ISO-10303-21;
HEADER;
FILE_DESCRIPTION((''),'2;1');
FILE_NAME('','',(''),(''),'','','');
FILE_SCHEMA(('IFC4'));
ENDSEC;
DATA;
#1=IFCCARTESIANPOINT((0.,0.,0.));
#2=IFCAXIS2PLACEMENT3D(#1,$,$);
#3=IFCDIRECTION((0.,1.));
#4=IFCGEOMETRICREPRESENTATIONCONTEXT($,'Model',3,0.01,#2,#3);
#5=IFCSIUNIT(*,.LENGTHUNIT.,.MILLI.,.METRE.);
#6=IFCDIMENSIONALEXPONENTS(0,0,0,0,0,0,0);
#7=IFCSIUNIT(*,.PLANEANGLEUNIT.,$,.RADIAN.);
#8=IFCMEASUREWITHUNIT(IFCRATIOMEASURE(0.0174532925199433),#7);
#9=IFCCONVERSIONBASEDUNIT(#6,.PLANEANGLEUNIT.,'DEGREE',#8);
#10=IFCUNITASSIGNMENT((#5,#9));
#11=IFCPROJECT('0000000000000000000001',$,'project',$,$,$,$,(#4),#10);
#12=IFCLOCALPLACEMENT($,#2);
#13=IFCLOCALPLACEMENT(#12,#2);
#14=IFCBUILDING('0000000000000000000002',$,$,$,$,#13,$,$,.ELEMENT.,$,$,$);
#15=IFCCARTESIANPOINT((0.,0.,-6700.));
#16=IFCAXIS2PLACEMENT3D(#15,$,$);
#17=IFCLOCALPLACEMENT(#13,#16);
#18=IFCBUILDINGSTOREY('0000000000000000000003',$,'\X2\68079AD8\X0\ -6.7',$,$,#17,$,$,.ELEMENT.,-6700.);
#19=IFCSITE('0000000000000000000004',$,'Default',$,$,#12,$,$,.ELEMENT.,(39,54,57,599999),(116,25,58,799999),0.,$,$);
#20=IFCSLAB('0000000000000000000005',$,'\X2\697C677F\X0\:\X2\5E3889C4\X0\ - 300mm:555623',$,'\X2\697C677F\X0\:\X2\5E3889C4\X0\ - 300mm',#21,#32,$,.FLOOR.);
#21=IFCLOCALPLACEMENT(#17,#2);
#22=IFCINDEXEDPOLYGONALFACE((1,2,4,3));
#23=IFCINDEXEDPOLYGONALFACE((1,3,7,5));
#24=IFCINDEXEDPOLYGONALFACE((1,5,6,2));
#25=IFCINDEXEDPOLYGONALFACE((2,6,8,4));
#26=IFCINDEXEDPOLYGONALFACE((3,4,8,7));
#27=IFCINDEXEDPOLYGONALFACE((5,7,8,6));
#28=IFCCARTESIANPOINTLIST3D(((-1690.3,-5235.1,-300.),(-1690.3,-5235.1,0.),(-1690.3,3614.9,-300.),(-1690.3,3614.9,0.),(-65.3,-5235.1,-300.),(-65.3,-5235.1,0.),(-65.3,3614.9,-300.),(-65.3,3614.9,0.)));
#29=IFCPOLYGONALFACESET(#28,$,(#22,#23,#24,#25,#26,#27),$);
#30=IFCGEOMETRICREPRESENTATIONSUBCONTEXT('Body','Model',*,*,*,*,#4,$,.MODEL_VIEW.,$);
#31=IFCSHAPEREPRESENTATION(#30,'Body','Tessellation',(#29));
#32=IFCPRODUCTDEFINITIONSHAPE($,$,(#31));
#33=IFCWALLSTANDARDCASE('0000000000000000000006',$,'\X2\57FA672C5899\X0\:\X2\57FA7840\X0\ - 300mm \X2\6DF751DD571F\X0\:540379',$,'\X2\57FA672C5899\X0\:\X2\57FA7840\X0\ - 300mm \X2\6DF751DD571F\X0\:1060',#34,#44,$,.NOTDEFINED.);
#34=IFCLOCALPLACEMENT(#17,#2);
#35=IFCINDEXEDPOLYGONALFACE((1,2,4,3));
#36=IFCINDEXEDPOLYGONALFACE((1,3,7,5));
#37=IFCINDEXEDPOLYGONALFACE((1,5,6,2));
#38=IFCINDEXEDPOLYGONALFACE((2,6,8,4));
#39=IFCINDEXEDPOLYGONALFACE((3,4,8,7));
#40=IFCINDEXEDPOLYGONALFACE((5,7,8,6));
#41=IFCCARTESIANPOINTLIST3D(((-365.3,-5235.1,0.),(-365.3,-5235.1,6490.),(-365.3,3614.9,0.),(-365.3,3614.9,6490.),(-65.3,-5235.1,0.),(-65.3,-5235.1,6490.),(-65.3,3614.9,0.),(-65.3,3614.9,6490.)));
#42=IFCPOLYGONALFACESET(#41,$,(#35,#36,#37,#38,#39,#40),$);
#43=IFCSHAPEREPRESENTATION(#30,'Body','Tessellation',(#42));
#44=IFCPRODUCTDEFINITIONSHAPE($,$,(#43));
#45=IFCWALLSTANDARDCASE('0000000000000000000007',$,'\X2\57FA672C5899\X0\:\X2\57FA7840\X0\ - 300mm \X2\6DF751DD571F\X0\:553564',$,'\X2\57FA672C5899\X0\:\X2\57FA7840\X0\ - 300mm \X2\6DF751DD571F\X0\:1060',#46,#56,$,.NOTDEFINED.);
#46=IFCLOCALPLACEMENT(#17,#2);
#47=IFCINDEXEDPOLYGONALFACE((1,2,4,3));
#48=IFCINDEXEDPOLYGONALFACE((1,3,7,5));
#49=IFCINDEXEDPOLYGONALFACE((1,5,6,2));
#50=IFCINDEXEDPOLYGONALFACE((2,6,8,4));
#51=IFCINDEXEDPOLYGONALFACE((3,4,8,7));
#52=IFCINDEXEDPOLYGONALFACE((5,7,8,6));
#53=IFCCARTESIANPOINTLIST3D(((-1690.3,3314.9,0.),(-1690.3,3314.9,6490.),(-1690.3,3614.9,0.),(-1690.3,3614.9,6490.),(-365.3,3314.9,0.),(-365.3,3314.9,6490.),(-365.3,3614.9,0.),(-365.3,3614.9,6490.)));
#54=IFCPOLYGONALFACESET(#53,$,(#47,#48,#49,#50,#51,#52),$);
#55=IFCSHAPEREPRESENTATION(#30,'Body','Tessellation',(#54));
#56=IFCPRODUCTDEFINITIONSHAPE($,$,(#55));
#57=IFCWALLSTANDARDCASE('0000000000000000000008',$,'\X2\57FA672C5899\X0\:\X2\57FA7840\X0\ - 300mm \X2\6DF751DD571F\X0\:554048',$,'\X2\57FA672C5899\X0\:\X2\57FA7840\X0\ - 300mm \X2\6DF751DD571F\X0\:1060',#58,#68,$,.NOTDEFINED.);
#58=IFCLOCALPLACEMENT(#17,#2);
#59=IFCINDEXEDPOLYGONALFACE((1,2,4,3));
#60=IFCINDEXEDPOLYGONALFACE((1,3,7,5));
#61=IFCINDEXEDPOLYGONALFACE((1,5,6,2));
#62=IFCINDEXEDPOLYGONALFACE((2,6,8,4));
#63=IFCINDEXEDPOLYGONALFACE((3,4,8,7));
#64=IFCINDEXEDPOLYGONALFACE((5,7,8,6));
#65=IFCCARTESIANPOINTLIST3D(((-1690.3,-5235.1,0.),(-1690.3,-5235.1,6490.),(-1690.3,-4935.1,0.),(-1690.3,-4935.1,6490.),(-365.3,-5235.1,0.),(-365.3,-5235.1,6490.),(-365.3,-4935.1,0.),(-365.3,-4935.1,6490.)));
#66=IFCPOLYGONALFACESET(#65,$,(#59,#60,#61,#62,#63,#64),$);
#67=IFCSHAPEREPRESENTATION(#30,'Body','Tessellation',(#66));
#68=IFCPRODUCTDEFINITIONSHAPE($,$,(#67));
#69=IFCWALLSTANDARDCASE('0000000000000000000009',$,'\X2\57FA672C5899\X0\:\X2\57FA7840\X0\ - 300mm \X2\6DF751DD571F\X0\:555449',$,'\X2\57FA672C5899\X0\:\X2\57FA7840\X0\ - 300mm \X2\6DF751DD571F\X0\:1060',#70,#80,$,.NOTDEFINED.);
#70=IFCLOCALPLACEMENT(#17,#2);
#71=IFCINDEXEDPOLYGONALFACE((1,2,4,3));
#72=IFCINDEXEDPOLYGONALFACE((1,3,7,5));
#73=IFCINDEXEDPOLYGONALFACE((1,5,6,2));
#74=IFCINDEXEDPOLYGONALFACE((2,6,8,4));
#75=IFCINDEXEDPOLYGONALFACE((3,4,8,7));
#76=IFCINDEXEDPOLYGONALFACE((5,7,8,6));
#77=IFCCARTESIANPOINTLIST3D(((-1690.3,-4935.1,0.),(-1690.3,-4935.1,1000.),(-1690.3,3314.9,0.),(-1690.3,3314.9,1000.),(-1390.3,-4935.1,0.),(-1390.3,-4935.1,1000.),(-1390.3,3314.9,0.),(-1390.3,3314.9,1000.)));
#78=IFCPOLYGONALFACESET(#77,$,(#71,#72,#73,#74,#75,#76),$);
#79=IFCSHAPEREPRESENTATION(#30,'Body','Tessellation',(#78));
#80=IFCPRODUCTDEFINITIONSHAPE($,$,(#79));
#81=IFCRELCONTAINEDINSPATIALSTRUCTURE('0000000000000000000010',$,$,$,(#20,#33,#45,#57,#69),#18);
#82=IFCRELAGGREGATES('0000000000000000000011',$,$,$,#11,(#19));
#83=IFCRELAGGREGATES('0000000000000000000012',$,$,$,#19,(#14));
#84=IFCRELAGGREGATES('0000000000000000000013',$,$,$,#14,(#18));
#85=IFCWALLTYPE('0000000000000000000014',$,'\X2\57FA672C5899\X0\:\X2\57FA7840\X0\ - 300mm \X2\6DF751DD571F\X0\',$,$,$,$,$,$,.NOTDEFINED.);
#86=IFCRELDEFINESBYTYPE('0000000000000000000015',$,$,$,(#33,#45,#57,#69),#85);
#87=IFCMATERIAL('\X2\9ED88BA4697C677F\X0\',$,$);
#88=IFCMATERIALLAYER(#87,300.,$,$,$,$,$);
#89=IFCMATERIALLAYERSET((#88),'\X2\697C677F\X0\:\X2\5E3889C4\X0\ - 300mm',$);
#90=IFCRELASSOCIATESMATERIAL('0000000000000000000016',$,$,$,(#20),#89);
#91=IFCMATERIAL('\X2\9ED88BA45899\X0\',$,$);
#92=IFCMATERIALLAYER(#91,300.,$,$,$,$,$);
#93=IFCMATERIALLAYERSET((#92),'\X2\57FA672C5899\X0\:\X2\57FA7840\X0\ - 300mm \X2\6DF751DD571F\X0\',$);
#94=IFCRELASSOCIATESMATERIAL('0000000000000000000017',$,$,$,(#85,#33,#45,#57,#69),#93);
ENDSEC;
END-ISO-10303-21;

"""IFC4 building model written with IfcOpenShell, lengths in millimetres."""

from ifc_helpers import new_model, entity, si_unit, converted_unit, direction, frame, frame_2d, origin, place, context, subcontext, project, spatial, polyline, rectangle, extrude, clip, bounded_halfspace, material, layer, layer_set, layer_usage, type_object, element, save


model = new_model("IFC4")

# Units and contexts
model_context = context("Model", 3, precision=0.01, world=origin(), true_north=direction((0.0, 1.0)))
body_context = subcontext(model_context, "Body", "Model", "MODEL_VIEW")
ifc_project = project(units=[si_unit("LENGTHUNIT", "METRE", prefix="MILLI"), converted_unit("PLANEANGLEUNIT", "DEGREE", entity("IfcRatioMeasure", 0.0174532925199433), si_unit("PLANEANGLEUNIT", "RADIAN"), dimensions=[0, 0, 0, 0, 0, 0, 0])], contexts=[model_context])

# Site, building, storey
site_placement = place(None, origin())
site = spatial("IfcSite", under=ifc_project, at=site_placement, Name="Default", CompositionType="ELEMENT", RefLatitude=(39, 54, 57, 599999), RefLongitude=(116, 25, 58, 799999), RefElevation=0.0)
building_placement = place(site_placement, origin())
building = spatial("IfcBuilding", under=site, at=building_placement, CompositionType="ELEMENT")
storey_placement = place(building_placement, frame((0.0, 0.0, -6700.0)))
storey = spatial("IfcBuildingStorey", under=building, at=storey_placement, Name="标高 -6.7", CompositionType="ELEMENT", Elevation=-6700.0)

# Slab
ifc_material_1 = material(Name="默认楼板")
ifc_layer_1 = layer(ifc_material_1, 300.0)
ifc_layer_set_1 = layer_set([ifc_layer_1], Name="楼板:常规 - 300mm")
ifc_layer_usage_1 = layer_usage(ifc_layer_set_1, "AXIS3", "POSITIVE", 0.0)
slab_placement = place(storey_placement, origin())
element("IfcSlab", 1, at=slab_placement, inside=storey, material=ifc_layer_usage_1, Name="楼板:常规 - 300mm:555623", ObjectType="楼板:常规 - 300mm", PredefinedType="FLOOR", context=body_context, shape_type="SweptSolid", body=[
    extrude(rectangle(XDim=8850.0, YDim=1625.0, at=frame_2d((0.0, 0.0), x_axis=(1.0, 0.0))), frame((-877.8, -810.1, 0.0), z_axis=(0.0, 0.0, -1.0), x_axis=(0.0, 1.0, 0.0)), (0.0, 0.0, 1.0), 300.0),
])

# Walls
ifc_material_2 = material(Name="默认墙")
ifc_layer_2 = layer(ifc_material_2, 300.0)
ifc_layer_set_2 = layer_set([ifc_layer_2], Name="基本墙:基础 - 300mm 混凝土")
ifc_layer_usage_2 = layer_usage(ifc_layer_set_2, "AXIS2", "NEGATIVE", 150.0)
wall_type = type_object("IfcWallType", Name="基本墙:基础 - 300mm 混凝土", PredefinedType="NOTDEFINED", material=ifc_layer_set_2)
wall_1_placement = place(storey_placement, frame((-215.3, 3614.9, 0.0), z_axis=(0.0, 0.0, 1.0), x_axis=(0.0, -1.0, 0.0)))
element("IfcWallStandardCase", 2, at=wall_1_placement, inside=storey, type_object=wall_type, material=ifc_layer_usage_2, Name="基本墙:基础 - 300mm 混凝土:540379", ObjectType="基本墙:基础 - 300mm 混凝土:1060", PredefinedType="NOTDEFINED", context=body_context, shape_type="Clipping", body=[
    clip(extrude(rectangle(XDim=8850.0, YDim=300.0, at=frame_2d((4425.0, 0.0), x_axis=(-1.0, 0.0))), origin(), (0.0, 0.0, 1.0), 6490.0), bounded_halfspace(frame((0.0, -150.0, 6490.0), z_axis=(0.0, 0.0, -1.0), x_axis=(-1.0, 0.0, 0.0)), True, frame((0.0, -150.0, 6490.0)), polyline([(0.0, 0.0), (300.0, 0.0), (8550.0, 0.0), (8850.0, 0.0), (8850.0, 300.0), (8551.5, 300.0), (300.0, 300.0), (0.0, 300.0), (0.0, 0.0)]))),
])
ifc_layer_usage_3 = layer_usage(ifc_layer_set_2, "AXIS2", "NEGATIVE", 150.0)
wall_2_placement = place(storey_placement, frame((-1690.3, 3464.9, 0.0)))
element("IfcWallStandardCase", 3, at=wall_2_placement, inside=storey, type_object=wall_type, material=ifc_layer_usage_3, Name="基本墙:基础 - 300mm 混凝土:553564", ObjectType="基本墙:基础 - 300mm 混凝土:1060", PredefinedType="NOTDEFINED", context=body_context, shape_type="Clipping", body=[
    clip(extrude(rectangle(XDim=1325.0, YDim=300.0, at=frame_2d((662.5, 0.0), x_axis=(-1.0, 0.0))), origin(), (0.0, 0.0, 1.0), 6490.0), bounded_halfspace(frame((150.0, -150.0, 6490.0), z_axis=(0.0, 0.0, -1.0), x_axis=(0.0, 1.0, 0.0)), True, frame((150.0, -150.0, 6490.0)), polyline([(0.0, 0.0), (1175.0, 0.0), (1175.0, 300.0), (0.0, 300.0), (0.0, 0.0)]))),
])
ifc_layer_usage_4 = layer_usage(ifc_layer_set_2, "AXIS2", "NEGATIVE", 150.0)
wall_3_placement = place(storey_placement, frame((-1690.3, -5085.1, 0.0)))
element("IfcWallStandardCase", 4, at=wall_3_placement, inside=storey, type_object=wall_type, material=ifc_layer_usage_4, Name="基本墙:基础 - 300mm 混凝土:554048", ObjectType="基本墙:基础 - 300mm 混凝土:1060", PredefinedType="NOTDEFINED", context=body_context, shape_type="Clipping", body=[
    clip(extrude(rectangle(XDim=1325.0, YDim=300.0, at=frame_2d((662.5, 0.0), x_axis=(-1.0, 0.0))), origin(), (0.0, 0.0, 1.0), 6490.0), bounded_halfspace(frame((150.0, -150.0, 6490.0), z_axis=(0.0, 0.0, -1.0), x_axis=(0.0, 1.0, 0.0)), True, frame((150.0, -150.0, 6490.0)), polyline([(0.0, 0.0), (1175.0, 0.0), (1175.0, 300.0), (0.0, 300.0), (0.0, 0.0)]))),
])
ifc_layer_usage_5 = layer_usage(ifc_layer_set_2, "AXIS2", "NEGATIVE", 150.0)
wall_4_placement = place(storey_placement, frame((-1540.3, 3314.9, 0.0), z_axis=(0.0, 0.0, 1.0), x_axis=(0.0, -1.0, 0.0)))
element("IfcWallStandardCase", 5, at=wall_4_placement, inside=storey, type_object=wall_type, material=ifc_layer_usage_5, Name="基本墙:基础 - 300mm 混凝土:555449", ObjectType="基本墙:基础 - 300mm 混凝土:1060", PredefinedType="NOTDEFINED", context=body_context, shape_type="SweptSolid", body=[
    extrude(rectangle(XDim=8250.0, YDim=300.0, at=frame_2d((4125.0, 0.0), x_axis=(-1.0, 0.0))), origin(), (0.0, 0.0, 1.0), 1000.0),
])

save(model, "model.ifc")
